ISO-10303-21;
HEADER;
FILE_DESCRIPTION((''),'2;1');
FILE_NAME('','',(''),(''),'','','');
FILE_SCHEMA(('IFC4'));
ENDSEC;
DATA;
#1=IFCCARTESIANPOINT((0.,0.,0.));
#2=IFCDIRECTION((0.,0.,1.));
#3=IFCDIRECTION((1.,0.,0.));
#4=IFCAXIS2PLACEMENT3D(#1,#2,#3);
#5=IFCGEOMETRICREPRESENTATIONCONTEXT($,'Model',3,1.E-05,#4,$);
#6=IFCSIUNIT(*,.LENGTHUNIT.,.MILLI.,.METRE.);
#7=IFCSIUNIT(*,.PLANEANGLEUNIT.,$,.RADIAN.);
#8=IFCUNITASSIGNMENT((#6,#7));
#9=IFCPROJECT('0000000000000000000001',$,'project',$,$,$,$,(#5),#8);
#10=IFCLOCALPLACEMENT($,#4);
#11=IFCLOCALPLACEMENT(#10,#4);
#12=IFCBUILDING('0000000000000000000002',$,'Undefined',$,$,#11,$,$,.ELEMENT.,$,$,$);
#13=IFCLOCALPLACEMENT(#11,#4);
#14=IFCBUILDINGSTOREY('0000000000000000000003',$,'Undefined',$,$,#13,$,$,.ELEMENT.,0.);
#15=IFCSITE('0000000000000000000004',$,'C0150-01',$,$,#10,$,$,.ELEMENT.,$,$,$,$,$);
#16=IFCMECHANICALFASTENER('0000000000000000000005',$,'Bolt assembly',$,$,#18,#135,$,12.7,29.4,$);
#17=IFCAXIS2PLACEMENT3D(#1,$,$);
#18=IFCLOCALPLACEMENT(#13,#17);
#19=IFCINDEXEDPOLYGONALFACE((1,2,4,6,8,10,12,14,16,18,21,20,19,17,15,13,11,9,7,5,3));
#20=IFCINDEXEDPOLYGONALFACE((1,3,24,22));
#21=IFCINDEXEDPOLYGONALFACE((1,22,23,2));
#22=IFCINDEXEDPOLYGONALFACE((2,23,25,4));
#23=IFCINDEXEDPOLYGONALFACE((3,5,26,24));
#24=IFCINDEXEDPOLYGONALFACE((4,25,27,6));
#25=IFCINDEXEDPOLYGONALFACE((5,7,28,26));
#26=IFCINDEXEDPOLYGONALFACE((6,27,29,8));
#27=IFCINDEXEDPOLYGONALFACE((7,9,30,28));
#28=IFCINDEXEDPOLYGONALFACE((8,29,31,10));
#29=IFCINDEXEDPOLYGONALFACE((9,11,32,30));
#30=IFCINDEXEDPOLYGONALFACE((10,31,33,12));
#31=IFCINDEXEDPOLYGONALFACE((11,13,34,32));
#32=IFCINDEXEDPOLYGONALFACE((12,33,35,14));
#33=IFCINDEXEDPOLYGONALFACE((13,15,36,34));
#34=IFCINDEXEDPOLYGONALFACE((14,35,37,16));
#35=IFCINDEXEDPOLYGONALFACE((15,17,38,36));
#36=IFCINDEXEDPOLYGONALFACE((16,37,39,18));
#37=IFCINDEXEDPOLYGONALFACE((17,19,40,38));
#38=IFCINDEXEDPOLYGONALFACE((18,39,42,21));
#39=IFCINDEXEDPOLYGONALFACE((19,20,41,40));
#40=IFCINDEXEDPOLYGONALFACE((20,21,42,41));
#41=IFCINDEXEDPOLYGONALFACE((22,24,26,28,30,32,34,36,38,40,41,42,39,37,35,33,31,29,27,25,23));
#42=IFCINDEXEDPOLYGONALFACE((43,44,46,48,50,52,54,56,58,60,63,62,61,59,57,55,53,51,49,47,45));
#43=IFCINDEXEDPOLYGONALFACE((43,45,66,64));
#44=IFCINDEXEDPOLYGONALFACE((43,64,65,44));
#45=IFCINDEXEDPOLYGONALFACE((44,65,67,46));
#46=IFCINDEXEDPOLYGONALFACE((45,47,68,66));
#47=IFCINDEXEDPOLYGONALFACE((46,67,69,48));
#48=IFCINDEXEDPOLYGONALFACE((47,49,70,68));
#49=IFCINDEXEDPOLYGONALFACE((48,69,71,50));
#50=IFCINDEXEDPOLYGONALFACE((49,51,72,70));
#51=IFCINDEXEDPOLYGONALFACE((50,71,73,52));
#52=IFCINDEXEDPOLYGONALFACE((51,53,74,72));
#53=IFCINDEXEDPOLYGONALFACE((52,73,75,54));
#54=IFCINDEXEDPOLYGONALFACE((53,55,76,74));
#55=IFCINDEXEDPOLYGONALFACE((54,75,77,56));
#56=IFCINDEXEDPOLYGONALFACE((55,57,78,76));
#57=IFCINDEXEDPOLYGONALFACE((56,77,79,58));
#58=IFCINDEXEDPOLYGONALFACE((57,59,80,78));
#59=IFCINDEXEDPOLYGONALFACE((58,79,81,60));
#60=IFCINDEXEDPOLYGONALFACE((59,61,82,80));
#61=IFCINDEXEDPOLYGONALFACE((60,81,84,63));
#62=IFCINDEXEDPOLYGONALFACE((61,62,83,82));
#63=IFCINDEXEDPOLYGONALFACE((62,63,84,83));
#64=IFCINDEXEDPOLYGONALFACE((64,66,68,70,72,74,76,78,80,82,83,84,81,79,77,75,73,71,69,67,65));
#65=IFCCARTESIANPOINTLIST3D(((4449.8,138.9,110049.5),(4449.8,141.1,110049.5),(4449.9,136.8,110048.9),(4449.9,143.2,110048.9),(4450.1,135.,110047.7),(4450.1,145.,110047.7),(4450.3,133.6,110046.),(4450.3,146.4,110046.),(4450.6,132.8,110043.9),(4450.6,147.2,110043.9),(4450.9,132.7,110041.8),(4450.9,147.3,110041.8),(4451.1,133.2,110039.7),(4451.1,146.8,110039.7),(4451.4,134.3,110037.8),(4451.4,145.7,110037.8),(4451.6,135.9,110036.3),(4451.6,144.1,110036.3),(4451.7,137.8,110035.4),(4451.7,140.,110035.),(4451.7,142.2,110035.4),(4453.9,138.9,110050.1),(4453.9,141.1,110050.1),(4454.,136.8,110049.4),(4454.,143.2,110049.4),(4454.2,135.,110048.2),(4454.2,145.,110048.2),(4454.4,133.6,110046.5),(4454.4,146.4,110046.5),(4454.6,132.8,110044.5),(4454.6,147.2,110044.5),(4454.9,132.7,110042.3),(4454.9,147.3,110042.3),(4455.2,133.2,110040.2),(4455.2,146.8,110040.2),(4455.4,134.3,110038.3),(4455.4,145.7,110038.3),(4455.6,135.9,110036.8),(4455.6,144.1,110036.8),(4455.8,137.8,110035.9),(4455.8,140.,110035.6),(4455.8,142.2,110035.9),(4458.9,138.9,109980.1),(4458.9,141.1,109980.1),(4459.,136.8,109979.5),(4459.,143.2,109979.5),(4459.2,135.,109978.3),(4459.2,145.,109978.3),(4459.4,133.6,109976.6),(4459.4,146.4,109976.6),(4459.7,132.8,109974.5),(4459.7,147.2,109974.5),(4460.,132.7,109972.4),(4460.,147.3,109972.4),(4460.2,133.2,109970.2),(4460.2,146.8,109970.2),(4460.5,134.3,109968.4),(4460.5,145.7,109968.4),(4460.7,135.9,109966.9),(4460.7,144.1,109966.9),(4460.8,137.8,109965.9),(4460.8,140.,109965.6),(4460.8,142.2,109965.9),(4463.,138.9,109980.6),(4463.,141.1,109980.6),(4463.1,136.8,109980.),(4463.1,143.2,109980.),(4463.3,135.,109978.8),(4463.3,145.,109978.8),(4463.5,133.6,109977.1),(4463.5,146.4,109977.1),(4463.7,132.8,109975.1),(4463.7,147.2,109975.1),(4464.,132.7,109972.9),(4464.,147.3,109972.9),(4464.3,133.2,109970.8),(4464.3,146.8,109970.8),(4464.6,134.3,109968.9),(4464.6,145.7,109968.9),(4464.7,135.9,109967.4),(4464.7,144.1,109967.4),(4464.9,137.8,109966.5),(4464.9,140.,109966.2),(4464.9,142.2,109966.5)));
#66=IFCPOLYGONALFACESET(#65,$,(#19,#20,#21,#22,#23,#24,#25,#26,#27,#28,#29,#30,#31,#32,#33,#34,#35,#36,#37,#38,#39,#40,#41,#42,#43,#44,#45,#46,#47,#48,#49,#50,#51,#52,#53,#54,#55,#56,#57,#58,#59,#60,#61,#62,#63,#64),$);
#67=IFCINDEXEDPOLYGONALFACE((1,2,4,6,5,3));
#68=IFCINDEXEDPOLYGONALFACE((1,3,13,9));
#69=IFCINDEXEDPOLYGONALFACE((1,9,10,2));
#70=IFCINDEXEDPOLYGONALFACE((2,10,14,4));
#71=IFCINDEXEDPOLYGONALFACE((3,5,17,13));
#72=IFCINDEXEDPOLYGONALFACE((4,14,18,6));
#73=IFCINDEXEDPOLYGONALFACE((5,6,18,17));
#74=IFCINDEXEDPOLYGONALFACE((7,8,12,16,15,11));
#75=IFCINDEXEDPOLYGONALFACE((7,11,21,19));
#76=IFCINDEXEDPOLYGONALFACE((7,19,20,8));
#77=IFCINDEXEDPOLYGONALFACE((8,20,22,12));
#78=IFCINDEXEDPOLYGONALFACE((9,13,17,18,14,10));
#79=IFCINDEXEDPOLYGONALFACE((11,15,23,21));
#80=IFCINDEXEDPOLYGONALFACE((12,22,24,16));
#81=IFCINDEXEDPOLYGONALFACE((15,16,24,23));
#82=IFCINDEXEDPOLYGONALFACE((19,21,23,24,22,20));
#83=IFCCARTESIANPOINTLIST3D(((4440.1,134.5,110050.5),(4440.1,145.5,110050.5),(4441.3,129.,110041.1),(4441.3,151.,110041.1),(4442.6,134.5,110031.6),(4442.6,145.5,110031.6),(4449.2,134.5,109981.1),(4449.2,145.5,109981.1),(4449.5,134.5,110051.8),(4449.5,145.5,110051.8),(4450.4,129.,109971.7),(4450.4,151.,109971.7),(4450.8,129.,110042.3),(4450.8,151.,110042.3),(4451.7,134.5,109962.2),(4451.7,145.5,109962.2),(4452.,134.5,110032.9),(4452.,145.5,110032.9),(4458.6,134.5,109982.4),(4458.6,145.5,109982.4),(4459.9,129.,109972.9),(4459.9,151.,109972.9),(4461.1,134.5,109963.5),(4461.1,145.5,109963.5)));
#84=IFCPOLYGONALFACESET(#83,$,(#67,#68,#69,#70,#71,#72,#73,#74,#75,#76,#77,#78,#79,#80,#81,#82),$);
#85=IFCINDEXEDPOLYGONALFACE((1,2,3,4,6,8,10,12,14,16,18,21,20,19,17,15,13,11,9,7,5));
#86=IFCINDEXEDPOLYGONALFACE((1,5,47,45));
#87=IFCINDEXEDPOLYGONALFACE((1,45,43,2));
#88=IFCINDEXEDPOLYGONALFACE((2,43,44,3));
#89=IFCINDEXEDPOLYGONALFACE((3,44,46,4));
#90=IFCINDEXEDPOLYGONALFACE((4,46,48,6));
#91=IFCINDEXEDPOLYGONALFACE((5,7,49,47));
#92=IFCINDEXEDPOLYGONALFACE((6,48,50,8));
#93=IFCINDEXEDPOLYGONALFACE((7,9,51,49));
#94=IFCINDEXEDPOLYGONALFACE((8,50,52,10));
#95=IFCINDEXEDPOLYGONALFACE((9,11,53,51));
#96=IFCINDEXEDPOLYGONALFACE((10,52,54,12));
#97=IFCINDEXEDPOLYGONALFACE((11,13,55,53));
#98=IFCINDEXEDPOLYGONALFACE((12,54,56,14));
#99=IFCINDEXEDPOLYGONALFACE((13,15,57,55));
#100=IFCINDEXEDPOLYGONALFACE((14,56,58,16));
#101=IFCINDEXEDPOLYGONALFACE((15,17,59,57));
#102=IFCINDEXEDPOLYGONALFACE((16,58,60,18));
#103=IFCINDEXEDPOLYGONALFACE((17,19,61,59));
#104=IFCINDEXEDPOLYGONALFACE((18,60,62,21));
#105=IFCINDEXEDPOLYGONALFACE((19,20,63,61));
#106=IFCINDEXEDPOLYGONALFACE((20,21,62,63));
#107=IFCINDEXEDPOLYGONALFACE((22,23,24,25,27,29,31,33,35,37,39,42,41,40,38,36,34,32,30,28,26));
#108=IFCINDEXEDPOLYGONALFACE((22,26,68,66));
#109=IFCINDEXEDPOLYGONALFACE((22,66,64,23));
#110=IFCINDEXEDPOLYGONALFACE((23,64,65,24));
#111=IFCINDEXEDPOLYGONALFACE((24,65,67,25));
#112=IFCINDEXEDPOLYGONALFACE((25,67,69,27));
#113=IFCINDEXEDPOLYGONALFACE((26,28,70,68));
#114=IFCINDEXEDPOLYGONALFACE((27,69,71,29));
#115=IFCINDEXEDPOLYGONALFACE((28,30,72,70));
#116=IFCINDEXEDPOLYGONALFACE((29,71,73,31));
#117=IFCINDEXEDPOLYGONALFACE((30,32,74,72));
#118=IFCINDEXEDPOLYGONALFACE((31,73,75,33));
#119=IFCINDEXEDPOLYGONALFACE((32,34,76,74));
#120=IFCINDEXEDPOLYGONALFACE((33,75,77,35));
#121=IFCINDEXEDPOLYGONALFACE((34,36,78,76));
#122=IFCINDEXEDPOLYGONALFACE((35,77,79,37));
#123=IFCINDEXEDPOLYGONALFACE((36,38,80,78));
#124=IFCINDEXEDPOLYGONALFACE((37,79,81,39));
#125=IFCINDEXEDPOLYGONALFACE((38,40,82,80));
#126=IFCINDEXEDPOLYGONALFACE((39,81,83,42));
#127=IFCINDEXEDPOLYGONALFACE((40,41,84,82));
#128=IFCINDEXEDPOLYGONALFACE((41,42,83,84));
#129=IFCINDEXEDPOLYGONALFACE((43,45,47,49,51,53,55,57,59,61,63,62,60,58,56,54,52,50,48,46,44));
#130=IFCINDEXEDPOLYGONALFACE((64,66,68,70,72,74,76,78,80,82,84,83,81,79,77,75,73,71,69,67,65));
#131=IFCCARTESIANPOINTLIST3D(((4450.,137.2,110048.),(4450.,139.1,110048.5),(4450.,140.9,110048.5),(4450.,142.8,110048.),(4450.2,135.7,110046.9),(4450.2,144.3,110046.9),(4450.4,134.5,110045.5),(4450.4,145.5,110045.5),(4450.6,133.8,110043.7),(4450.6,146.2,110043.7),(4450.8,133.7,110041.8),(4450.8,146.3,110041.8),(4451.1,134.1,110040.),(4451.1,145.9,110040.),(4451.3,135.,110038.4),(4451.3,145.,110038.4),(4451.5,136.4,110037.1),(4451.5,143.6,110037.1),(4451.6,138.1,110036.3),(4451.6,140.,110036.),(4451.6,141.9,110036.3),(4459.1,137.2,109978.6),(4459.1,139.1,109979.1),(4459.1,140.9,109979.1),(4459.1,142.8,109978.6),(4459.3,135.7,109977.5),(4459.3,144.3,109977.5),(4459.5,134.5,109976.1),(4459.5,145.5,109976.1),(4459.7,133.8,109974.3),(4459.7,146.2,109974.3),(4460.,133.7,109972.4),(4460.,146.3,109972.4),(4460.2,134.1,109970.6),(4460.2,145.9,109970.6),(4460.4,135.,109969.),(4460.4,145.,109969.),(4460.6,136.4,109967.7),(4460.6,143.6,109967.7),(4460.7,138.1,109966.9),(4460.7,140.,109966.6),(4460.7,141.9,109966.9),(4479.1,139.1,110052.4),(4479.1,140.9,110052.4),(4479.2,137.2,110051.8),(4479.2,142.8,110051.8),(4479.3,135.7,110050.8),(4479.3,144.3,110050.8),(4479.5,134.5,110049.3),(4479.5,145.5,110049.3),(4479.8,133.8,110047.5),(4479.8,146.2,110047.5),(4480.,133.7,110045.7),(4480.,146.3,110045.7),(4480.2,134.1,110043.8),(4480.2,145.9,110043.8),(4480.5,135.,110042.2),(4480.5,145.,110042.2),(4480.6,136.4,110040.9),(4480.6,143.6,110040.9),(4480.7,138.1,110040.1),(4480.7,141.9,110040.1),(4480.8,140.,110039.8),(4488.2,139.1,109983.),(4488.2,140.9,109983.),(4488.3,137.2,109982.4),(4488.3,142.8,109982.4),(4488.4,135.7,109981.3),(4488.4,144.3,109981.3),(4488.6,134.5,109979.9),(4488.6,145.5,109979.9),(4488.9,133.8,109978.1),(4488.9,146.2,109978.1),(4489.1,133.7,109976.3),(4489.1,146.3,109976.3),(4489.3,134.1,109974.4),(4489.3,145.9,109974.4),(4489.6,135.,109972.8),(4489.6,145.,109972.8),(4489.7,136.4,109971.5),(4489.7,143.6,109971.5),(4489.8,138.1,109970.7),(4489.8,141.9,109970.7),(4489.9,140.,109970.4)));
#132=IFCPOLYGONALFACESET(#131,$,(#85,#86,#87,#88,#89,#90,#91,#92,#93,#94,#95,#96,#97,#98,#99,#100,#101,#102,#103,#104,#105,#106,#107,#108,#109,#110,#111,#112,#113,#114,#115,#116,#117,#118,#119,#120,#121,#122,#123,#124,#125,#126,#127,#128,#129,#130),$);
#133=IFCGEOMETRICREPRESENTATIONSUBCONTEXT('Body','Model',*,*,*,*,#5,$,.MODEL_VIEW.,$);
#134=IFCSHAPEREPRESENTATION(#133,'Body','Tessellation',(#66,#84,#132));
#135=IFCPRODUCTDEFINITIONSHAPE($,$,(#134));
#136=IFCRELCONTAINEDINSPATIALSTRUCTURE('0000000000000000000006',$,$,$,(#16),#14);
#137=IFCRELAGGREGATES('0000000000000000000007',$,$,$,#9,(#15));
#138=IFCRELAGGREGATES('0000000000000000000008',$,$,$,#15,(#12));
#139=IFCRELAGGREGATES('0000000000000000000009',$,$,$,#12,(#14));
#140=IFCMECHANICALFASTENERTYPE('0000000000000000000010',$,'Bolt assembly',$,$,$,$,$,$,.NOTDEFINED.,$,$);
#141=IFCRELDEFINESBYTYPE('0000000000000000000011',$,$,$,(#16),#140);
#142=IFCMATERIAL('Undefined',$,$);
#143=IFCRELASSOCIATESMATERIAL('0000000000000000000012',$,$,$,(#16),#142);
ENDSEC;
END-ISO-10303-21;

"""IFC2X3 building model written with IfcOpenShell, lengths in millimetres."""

from ifc_helpers import new_model, si_unit, frame, origin_with_axes, origin_2d_with_axis, place, context, subcontext, project, spatial, polyline, circle, outline, extrude, source, transform, mapped, material, type_object, element, save


model = new_model("IFC2X3")

# Units and contexts
model_context = context("Model", 3, precision=1e-05, world=origin_with_axes())
body_context = subcontext(model_context, "Body", "Model", "MODEL_VIEW")
ifc_project = project(units=[si_unit("LENGTHUNIT", "METRE", prefix="MILLI"), si_unit("PLANEANGLEUNIT", "RADIAN")], contexts=[model_context])

# Site, building, storey
site_placement = place(None, origin_with_axes())
site = spatial("IfcSite", under=ifc_project, at=site_placement, Name="C0150-01", CompositionType="ELEMENT")
building_placement = place(site_placement, origin_with_axes())
building = spatial("IfcBuilding", under=site, at=building_placement, Name="Undefined", CompositionType="ELEMENT")
storey_placement = place(building_placement, origin_with_axes())
storey = spatial("IfcBuildingStorey", under=building, at=storey_placement, Name="Undefined", CompositionType="ELEMENT", Elevation=0.0)

# Mechanical fastener
ifc_material_1 = material(Name="Undefined")
mechanical_fastener_type = type_object("IfcMechanicalFastenerType", Name="Bolt assembly")
shared_shape_1 = source(origin_with_axes(), body_context, "Body", "SweptSolid", [
    extrude(circle(Radius=7.3, at=origin_2d_with_axis()), frame((0.0, 0.0, 0.0), z_axis=(0.0, 1.0, 0.0), x_axis=(1.0, 0.0, 0.0)), (0.0, 0.0, 1.0), 4.1),
    extrude(outline(polyline([(9.5, -5.5), (9.5, 5.5), (0.0, 11.0), (-9.5, 5.5), (-9.5, -5.5), (0.0, -11.0), (9.5, -5.5)])), frame((0.0, -9.5, 0.0), z_axis=(0.0, 1.0, 0.0), x_axis=(1.0, 0.0, 0.0)), (0.0, 0.0, 1.0), 9.5),
    extrude(circle(Radius=6.3, at=origin_2d_with_axis()), frame((0.0, 0.0, 0.0), z_axis=(0.0, 1.0, 0.0), x_axis=(1.0, 0.0, 0.0)), (0.0, 0.0, 1.0), 29.4),
])
for number, where, z_axis, x_axis, name in (
    (1, (4450.8, 140.0, 110042.3), (0.0, -1.0, 0.0), (0.130054, 0.0, -0.991507), "Bolt assembly"),
):
    element("IfcMechanicalFastener", number, at=place(storey_placement, frame(where, z_axis=z_axis, x_axis=x_axis)), inside=storey, type_object=mechanical_fastener_type, material=ifc_material_1, Name=name, NominalDiameter=12.7, NominalLength=29.4, context=body_context, shape_type="MappedRepresentation", body=[
        mapped(shared_shape_1, transform((0.0, 0.0, 0.0))),
        mapped(shared_shape_1, transform((70.0, 0.0, 0.0))),
    ])

save(model, "model.ifc")
